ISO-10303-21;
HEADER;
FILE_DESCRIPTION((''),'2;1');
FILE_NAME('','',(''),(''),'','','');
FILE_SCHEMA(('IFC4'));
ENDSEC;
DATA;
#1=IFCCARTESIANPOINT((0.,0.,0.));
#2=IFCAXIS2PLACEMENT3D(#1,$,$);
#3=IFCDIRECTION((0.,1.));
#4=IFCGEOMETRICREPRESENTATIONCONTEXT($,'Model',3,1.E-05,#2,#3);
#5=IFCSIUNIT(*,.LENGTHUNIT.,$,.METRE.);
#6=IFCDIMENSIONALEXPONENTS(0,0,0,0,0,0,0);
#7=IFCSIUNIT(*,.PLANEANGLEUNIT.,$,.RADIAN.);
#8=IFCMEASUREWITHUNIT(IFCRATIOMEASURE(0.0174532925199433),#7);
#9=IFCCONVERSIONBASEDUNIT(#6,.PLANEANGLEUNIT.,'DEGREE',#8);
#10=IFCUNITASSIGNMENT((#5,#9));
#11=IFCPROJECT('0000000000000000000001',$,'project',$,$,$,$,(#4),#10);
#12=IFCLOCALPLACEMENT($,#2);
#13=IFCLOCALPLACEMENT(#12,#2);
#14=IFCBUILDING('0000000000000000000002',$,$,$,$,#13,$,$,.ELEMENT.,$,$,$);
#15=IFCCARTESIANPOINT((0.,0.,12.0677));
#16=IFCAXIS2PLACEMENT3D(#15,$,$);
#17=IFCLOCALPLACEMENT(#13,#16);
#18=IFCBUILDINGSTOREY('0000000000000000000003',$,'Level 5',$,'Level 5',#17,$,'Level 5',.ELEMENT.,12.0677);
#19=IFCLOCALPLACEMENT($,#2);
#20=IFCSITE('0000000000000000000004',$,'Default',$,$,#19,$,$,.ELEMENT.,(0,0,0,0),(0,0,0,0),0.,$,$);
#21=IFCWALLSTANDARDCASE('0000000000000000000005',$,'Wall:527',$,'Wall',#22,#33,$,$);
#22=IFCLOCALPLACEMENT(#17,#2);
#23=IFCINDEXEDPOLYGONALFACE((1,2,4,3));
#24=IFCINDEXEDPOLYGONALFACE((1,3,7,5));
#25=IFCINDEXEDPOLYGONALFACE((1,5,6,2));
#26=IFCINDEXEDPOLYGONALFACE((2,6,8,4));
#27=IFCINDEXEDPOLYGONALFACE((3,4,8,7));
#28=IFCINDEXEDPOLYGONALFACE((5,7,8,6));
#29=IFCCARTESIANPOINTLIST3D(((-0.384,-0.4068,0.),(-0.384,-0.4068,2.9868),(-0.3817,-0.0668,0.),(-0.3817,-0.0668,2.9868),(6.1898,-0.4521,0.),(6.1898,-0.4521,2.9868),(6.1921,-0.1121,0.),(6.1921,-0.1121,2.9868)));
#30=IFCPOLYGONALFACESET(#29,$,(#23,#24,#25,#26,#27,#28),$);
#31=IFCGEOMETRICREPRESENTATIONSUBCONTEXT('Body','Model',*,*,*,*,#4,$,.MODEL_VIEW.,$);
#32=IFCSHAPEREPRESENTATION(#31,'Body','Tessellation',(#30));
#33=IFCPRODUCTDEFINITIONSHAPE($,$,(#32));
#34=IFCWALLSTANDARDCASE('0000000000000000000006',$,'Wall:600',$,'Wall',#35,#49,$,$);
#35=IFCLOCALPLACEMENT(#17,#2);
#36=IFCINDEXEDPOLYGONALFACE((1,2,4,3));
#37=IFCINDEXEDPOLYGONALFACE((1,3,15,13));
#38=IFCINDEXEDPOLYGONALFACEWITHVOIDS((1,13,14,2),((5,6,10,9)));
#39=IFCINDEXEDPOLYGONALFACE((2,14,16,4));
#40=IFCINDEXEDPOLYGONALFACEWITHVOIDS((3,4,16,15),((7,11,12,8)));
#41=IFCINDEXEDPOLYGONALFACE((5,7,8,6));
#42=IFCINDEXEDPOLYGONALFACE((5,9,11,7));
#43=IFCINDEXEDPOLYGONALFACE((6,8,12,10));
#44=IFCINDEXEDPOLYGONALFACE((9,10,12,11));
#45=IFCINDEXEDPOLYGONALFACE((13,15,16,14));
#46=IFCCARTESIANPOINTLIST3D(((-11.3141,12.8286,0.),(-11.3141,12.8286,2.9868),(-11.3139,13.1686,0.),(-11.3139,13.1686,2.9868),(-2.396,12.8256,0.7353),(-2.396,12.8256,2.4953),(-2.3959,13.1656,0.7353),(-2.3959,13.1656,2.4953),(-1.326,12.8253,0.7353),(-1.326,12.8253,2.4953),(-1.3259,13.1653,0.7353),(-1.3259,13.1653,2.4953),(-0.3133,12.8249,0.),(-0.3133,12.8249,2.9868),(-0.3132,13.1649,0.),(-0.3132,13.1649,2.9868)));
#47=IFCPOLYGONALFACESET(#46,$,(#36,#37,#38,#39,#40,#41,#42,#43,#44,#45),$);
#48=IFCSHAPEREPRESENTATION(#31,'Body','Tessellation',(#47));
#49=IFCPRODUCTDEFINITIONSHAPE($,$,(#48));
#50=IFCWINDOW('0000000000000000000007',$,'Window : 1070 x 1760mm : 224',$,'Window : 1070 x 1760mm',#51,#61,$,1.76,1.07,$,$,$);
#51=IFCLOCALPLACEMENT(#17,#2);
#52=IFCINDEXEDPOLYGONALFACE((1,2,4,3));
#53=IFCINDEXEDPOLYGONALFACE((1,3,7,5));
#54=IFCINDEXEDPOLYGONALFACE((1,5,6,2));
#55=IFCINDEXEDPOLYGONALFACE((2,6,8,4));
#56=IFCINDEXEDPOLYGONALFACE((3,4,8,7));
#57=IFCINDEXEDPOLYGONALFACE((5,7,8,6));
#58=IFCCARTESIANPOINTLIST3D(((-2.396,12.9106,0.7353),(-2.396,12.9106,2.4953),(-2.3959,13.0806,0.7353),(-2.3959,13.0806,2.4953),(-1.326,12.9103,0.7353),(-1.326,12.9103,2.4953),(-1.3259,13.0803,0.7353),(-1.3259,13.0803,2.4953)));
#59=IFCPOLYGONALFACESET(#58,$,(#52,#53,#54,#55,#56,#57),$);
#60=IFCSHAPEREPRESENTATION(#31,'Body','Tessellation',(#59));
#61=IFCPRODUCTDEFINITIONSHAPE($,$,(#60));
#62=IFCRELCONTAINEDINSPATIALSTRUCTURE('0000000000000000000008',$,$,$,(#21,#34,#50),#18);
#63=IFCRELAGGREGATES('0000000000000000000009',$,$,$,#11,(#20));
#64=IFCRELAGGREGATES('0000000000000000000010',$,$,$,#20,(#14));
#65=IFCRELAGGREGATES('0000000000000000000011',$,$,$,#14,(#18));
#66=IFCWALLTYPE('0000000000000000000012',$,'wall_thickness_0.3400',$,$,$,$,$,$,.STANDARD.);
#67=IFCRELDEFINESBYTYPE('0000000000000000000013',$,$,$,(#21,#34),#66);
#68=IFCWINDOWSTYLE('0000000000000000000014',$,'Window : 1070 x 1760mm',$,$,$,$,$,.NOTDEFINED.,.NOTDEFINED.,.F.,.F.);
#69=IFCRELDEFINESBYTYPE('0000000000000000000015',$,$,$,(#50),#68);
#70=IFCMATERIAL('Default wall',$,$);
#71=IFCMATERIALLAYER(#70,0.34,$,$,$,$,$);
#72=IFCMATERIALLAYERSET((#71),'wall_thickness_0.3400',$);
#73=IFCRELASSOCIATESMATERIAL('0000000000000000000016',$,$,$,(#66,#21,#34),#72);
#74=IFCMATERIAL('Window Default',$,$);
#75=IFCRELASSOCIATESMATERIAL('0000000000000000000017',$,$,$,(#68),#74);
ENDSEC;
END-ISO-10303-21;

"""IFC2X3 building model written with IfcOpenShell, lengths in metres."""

from ifc_helpers import new_model, entity, si_unit, converted_unit, direction, frame, frame_2d, origin, origin_2d_with_axis, place, context, subcontext, project, spatial, polyline, rectangle, outline, extrude, source, transform, mapped, material, layer, layer_set, layer_usage, type_object, type_shapes, element, fill, save


model = new_model("IFC2X3")

# Units and contexts
model_context = context("Model", 3, precision=1e-05, world=origin(), true_north=direction((0.0, 1.0)))
body_context = subcontext(model_context, "Body", "Model", "MODEL_VIEW")
ifc_project = project(units=[si_unit("LENGTHUNIT", "METRE"), converted_unit("PLANEANGLEUNIT", "DEGREE", entity("IfcRatioMeasure", 0.0174532925199433), si_unit("PLANEANGLEUNIT", "RADIAN"), dimensions=[0, 0, 0, 0, 0, 0, 0])], contexts=[model_context])

# Site, building, storey
site_placement = place(None, origin())
site = spatial("IfcSite", under=ifc_project, at=site_placement, Name="Default", CompositionType="ELEMENT", RefLatitude=(0, 0, 0, 0), RefLongitude=(0, 0, 0, 0), RefElevation=0.0)
placement_1 = place(None, origin())
building_placement = place(placement_1, origin())
building = spatial("IfcBuilding", under=site, at=building_placement, CompositionType="ELEMENT")
storey_placement = place(building_placement, frame((0.0, 0.0, 12.0677)))
storey = spatial("IfcBuildingStorey", under=building, at=storey_placement, Name="Level 5", ObjectType="Level 5", LongName="Level 5", CompositionType="ELEMENT", Elevation=12.0677)

# Shared definitions
ifc_material_1 = material(Name="Default wall")

# Shared definitions
ifc_material_2 = material(Name="Window Default")

# Wall
ifc_layer_1 = layer(ifc_material_1, 0.34)
ifc_layer_set_1 = layer_set([ifc_layer_1], Name="wall_thickness_0.3400")
ifc_layer_usage_1 = layer_usage(ifc_layer_set_1, "AXIS2", "POSITIVE", -0.17)
wall_type_1 = type_object("IfcWallType", Name="wall_thickness_0.3400", PredefinedType="STANDARD", material=ifc_layer_set_1)
wall_1_placement = place(storey_placement, frame((-0.3828, -0.2368, 0.0), z_axis=(0.0, 0.0, 1.0), x_axis=(0.999976, -0.006896, 0.0)))
element("IfcWallStandardCase", 1, at=wall_1_placement, inside=storey, type_object=wall_type_1, material=ifc_layer_usage_1, Name="Wall:527", ObjectType="Wall", context=body_context, shape_type="SweptSolid", body=[
    extrude(outline(polyline([(6.5739, -0.17), (6.5739, 0.17), (0.0, 0.17), (0.0, -0.17), (6.5739, -0.17)])), origin(), (0.0, 0.0, 1.0), 2.9868),
])

# Wall, opening, window
wall_2_placement = place(storey_placement, frame((-11.314, 12.9986, 0.0), z_axis=(0.0, 0.0, 1.0), x_axis=(1.0, -0.000329, 0.0)))
wall_2 = element("IfcWallStandardCase", 2, at=wall_2_placement, inside=storey, type_object=wall_type_1, material=ifc_layer_usage_1, Name="Wall:600", ObjectType="Wall", context=body_context, shape_type="SweptSolid", body=[
    extrude(outline(polyline([(11.0007, -0.17), (11.0007, 0.17), (0.0, 0.17), (0.0, -0.17), (11.0007, -0.17)])), origin(), (0.0, 0.0, 1.0), 2.9868),
])
opening_1_placement = place(wall_2_placement, frame((8.9181, -0.17, 0.7353)))
opening_1 = element("IfcOpeningElement", 3, at=opening_1_placement, cuts=wall_2, ObjectType="Opening", context=body_context, shape_type="SweptSolid", body=[
    extrude(rectangle(XDim=1.07, YDim=1.76, at=frame_2d((0.88, 0.535), x_axis=(0.0, 1.0))), frame((0.0, 0.0, 0.0), z_axis=(0.0, 1.0, 0.0), x_axis=(0.0, 0.0, 1.0)), (0.0, 0.0, 1.0), 0.34),
])
window_style_1 = type_object("IfcWindowStyle", Name="Window : 1070 x 1760mm", ConstructionType="NOTDEFINED", OperationType="NOTDEFINED", ParameterTakesPrecedence=False, Sizeable=False, material=ifc_material_2)
shared_shape_1 = source(origin(), body_context, "Body", "SweptSolid", [
    extrude(rectangle(XDim=0.17, YDim=1.07, at=origin_2d_with_axis()), frame((0.535, 0.17, 0.0), z_axis=(0.0, 0.0, 1.0), x_axis=(0.0, 1.0, 0.0)), (0.0, 0.0, 1.0), 1.76),
])
type_shapes(window_style_1, [shared_shape_1])
window_1_placement = place(opening_1_placement, origin())
window_1 = element("IfcWindow", 4, at=window_1_placement, inside=storey, type_object=window_style_1, Name="Window : 1070 x 1760mm : 224", ObjectType="Window : 1070 x 1760mm", OverallHeight=1.76, OverallWidth=1.07, context=body_context, shape_type="MappedRepresentation", body=[
    mapped(shared_shape_1, transform((0.0, 0.0, 0.0), scale=1.0)),
])
fill(opening_1, window_1)

save(model, "model.ifc")
